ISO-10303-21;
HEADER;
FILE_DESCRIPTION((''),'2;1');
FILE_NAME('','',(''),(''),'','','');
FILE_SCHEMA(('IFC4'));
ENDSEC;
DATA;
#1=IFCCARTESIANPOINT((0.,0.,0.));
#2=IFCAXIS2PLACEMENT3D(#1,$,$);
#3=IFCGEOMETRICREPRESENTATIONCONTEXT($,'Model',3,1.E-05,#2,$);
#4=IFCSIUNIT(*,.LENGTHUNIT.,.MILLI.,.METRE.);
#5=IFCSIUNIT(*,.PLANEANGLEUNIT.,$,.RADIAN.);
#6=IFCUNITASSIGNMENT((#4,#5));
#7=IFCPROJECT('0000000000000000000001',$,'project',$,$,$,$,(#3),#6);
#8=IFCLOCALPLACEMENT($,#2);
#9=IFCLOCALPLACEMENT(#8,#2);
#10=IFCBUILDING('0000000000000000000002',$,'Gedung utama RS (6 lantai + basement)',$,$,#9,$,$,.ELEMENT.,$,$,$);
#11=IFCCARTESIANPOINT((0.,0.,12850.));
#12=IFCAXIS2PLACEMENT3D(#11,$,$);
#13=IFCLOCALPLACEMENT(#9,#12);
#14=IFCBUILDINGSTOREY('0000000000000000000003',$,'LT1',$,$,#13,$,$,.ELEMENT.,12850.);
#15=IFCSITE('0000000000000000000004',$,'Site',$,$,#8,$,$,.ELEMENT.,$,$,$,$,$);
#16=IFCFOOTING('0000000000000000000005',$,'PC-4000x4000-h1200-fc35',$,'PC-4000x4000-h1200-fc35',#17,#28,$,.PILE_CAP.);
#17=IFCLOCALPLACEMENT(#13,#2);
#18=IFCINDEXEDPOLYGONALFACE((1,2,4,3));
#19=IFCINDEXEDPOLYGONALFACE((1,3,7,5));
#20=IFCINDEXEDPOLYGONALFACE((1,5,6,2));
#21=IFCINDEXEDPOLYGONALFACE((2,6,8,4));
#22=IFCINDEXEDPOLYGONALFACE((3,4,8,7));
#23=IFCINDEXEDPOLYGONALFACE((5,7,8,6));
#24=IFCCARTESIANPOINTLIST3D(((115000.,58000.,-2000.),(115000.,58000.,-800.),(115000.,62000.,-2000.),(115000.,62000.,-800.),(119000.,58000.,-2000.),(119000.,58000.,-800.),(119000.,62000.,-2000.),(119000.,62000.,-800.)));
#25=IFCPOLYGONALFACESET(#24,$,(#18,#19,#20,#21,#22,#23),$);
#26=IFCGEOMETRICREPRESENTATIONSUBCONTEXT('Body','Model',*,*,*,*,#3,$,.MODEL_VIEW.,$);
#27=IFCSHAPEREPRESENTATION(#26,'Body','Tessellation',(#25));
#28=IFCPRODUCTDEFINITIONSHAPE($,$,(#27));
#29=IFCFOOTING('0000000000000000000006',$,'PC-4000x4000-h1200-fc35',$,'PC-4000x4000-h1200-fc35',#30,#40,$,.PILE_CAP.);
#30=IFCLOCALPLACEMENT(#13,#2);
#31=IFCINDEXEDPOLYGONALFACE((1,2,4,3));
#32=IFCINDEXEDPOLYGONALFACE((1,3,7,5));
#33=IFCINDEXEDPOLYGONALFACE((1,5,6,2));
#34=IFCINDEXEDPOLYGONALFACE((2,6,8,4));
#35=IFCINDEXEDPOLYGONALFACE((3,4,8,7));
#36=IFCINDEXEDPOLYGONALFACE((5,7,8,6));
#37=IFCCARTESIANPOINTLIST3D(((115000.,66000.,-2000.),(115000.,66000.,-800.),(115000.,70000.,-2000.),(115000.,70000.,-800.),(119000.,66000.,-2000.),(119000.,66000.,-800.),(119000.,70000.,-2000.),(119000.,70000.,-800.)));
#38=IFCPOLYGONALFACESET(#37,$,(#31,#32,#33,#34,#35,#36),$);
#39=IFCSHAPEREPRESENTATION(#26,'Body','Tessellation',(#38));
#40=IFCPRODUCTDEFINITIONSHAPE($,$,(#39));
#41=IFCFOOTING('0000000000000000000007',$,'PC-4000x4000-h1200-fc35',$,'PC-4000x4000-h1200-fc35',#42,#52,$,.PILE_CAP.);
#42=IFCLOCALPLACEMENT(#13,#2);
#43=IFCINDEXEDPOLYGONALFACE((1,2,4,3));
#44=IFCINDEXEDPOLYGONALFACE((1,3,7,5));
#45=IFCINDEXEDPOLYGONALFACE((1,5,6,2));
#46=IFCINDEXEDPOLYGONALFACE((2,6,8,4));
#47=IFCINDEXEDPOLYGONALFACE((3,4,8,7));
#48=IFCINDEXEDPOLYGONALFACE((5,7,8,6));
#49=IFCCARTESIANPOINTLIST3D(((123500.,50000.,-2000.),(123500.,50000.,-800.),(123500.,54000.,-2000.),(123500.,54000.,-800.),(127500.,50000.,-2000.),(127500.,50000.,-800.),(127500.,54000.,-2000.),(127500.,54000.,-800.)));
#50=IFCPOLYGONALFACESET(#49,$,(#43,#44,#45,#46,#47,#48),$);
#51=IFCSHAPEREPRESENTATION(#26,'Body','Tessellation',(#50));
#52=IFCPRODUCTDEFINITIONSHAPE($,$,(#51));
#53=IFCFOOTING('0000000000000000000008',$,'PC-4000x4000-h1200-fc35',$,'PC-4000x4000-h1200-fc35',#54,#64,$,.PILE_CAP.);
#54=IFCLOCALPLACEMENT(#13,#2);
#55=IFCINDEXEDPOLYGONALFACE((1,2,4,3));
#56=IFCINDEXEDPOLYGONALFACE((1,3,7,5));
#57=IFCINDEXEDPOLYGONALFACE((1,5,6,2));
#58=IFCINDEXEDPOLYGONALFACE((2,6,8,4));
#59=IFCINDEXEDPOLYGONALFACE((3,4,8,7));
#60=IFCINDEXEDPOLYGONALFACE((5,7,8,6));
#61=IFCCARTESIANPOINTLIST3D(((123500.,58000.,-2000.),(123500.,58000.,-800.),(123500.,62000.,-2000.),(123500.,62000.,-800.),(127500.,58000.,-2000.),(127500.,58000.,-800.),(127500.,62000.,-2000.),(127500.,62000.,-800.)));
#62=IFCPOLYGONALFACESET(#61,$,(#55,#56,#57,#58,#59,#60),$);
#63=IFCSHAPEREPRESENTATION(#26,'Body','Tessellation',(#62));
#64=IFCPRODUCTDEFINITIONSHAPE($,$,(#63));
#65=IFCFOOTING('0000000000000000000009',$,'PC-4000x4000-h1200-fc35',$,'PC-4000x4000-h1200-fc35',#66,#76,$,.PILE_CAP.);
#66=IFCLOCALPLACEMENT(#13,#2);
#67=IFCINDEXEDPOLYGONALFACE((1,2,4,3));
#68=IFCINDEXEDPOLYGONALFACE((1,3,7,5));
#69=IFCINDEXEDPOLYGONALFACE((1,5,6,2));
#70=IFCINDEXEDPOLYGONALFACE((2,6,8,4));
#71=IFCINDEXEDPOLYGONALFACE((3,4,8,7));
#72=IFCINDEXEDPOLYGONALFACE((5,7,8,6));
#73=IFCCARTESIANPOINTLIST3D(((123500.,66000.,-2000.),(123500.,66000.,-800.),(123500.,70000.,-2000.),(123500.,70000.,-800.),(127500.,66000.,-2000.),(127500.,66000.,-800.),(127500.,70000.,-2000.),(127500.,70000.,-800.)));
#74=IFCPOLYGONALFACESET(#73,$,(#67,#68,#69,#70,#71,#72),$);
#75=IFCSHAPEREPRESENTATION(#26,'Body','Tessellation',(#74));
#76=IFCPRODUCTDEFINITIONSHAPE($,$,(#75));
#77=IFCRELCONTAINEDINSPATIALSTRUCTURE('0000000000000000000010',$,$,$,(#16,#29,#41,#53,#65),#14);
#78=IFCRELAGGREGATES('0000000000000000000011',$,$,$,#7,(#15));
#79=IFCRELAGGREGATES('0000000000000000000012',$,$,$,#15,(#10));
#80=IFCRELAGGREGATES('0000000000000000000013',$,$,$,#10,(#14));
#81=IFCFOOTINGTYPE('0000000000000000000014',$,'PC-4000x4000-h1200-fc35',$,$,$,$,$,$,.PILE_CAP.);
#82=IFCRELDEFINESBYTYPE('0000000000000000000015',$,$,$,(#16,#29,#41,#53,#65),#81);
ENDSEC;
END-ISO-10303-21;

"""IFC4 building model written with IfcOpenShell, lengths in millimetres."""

from ifc_helpers import new_model, si_unit, frame, origin, origin_2d, place, context, subcontext, project, spatial, rectangle, extrude, material_profile, profile_set, profile_usage, type_object, element, save


model = new_model("IFC4")

# Units and contexts
model_context = context("Model", 3, precision=1e-05, world=origin())
body_context = subcontext(model_context, "Body", "Model", "MODEL_VIEW")
ifc_project = project(units=[si_unit("LENGTHUNIT", "METRE", prefix="MILLI"), si_unit("PLANEANGLEUNIT", "RADIAN")], contexts=[model_context])

# Site, building, storey
site_placement = place(None, origin())
site = spatial("IfcSite", under=ifc_project, at=site_placement, Name="Site", CompositionType="ELEMENT")
building_placement = place(site_placement, origin())
building = spatial("IfcBuilding", under=site, at=building_placement, Name="Gedung utama RS (6 lantai + basement)", CompositionType="ELEMENT")
storey_placement = place(building_placement, frame((0.0, 0.0, 12850.0)))
storey = spatial("IfcBuildingStorey", under=building, at=storey_placement, Name="LT1", CompositionType="ELEMENT", Elevation=12850.0)

# Footings
ifc_material_profile_1 = material_profile(None, rectangle(XDim=4000.0, YDim=4000.0, at=origin_2d()), Name="PC-4000x4000-h1200-fc35")
ifc_profile_set_1 = profile_set([ifc_material_profile_1], Name="PC-4000x4000-h1200-fc35")
ifc_profile_usage_1 = profile_usage(ifc_profile_set_1, cardinal=5)
footing_type_1 = type_object("IfcFootingType", Name="PC-4000x4000-h1200-fc35", PredefinedType="PILE_CAP", material=ifc_profile_set_1)
for number, where, z_axis, x_axis, name in (
    (1, (117000.0, 60000.0, -2000.0), (0.0, 0.0, 1.0), (1.0, 0.0, 0.0), "PC-4000x4000-h1200-fc35"),
    (2, (117000.0, 68000.0, -2000.0), (0.0, 0.0, 1.0), (1.0, 0.0, 0.0), "PC-4000x4000-h1200-fc35"),
    (3, (125500.0, 52000.0, -2000.0), (0.0, 0.0, 1.0), (1.0, 0.0, 0.0), "PC-4000x4000-h1200-fc35"),
    (4, (125500.0, 60000.0, -2000.0), (0.0, 0.0, 1.0), (1.0, 0.0, 0.0), "PC-4000x4000-h1200-fc35"),
    (5, (125500.0, 68000.0, -2000.0), (0.0, 0.0, 1.0), (1.0, 0.0, 0.0), "PC-4000x4000-h1200-fc35"),
):
    element("IfcFooting", number, at=place(storey_placement, frame(where, z_axis=z_axis, x_axis=x_axis)), inside=storey, type_object=footing_type_1, material=ifc_profile_usage_1, Name=name, ObjectType="PC-4000x4000-h1200-fc35", PredefinedType="PILE_CAP", context=body_context, shape_type="SweptSolid", body=[
        extrude(rectangle(XDim=4000.0, YDim=4000.0, at=origin_2d()), origin(), (0.0, 0.0, 1.0), 1200.0),
    ])

save(model, "model.ifc")
